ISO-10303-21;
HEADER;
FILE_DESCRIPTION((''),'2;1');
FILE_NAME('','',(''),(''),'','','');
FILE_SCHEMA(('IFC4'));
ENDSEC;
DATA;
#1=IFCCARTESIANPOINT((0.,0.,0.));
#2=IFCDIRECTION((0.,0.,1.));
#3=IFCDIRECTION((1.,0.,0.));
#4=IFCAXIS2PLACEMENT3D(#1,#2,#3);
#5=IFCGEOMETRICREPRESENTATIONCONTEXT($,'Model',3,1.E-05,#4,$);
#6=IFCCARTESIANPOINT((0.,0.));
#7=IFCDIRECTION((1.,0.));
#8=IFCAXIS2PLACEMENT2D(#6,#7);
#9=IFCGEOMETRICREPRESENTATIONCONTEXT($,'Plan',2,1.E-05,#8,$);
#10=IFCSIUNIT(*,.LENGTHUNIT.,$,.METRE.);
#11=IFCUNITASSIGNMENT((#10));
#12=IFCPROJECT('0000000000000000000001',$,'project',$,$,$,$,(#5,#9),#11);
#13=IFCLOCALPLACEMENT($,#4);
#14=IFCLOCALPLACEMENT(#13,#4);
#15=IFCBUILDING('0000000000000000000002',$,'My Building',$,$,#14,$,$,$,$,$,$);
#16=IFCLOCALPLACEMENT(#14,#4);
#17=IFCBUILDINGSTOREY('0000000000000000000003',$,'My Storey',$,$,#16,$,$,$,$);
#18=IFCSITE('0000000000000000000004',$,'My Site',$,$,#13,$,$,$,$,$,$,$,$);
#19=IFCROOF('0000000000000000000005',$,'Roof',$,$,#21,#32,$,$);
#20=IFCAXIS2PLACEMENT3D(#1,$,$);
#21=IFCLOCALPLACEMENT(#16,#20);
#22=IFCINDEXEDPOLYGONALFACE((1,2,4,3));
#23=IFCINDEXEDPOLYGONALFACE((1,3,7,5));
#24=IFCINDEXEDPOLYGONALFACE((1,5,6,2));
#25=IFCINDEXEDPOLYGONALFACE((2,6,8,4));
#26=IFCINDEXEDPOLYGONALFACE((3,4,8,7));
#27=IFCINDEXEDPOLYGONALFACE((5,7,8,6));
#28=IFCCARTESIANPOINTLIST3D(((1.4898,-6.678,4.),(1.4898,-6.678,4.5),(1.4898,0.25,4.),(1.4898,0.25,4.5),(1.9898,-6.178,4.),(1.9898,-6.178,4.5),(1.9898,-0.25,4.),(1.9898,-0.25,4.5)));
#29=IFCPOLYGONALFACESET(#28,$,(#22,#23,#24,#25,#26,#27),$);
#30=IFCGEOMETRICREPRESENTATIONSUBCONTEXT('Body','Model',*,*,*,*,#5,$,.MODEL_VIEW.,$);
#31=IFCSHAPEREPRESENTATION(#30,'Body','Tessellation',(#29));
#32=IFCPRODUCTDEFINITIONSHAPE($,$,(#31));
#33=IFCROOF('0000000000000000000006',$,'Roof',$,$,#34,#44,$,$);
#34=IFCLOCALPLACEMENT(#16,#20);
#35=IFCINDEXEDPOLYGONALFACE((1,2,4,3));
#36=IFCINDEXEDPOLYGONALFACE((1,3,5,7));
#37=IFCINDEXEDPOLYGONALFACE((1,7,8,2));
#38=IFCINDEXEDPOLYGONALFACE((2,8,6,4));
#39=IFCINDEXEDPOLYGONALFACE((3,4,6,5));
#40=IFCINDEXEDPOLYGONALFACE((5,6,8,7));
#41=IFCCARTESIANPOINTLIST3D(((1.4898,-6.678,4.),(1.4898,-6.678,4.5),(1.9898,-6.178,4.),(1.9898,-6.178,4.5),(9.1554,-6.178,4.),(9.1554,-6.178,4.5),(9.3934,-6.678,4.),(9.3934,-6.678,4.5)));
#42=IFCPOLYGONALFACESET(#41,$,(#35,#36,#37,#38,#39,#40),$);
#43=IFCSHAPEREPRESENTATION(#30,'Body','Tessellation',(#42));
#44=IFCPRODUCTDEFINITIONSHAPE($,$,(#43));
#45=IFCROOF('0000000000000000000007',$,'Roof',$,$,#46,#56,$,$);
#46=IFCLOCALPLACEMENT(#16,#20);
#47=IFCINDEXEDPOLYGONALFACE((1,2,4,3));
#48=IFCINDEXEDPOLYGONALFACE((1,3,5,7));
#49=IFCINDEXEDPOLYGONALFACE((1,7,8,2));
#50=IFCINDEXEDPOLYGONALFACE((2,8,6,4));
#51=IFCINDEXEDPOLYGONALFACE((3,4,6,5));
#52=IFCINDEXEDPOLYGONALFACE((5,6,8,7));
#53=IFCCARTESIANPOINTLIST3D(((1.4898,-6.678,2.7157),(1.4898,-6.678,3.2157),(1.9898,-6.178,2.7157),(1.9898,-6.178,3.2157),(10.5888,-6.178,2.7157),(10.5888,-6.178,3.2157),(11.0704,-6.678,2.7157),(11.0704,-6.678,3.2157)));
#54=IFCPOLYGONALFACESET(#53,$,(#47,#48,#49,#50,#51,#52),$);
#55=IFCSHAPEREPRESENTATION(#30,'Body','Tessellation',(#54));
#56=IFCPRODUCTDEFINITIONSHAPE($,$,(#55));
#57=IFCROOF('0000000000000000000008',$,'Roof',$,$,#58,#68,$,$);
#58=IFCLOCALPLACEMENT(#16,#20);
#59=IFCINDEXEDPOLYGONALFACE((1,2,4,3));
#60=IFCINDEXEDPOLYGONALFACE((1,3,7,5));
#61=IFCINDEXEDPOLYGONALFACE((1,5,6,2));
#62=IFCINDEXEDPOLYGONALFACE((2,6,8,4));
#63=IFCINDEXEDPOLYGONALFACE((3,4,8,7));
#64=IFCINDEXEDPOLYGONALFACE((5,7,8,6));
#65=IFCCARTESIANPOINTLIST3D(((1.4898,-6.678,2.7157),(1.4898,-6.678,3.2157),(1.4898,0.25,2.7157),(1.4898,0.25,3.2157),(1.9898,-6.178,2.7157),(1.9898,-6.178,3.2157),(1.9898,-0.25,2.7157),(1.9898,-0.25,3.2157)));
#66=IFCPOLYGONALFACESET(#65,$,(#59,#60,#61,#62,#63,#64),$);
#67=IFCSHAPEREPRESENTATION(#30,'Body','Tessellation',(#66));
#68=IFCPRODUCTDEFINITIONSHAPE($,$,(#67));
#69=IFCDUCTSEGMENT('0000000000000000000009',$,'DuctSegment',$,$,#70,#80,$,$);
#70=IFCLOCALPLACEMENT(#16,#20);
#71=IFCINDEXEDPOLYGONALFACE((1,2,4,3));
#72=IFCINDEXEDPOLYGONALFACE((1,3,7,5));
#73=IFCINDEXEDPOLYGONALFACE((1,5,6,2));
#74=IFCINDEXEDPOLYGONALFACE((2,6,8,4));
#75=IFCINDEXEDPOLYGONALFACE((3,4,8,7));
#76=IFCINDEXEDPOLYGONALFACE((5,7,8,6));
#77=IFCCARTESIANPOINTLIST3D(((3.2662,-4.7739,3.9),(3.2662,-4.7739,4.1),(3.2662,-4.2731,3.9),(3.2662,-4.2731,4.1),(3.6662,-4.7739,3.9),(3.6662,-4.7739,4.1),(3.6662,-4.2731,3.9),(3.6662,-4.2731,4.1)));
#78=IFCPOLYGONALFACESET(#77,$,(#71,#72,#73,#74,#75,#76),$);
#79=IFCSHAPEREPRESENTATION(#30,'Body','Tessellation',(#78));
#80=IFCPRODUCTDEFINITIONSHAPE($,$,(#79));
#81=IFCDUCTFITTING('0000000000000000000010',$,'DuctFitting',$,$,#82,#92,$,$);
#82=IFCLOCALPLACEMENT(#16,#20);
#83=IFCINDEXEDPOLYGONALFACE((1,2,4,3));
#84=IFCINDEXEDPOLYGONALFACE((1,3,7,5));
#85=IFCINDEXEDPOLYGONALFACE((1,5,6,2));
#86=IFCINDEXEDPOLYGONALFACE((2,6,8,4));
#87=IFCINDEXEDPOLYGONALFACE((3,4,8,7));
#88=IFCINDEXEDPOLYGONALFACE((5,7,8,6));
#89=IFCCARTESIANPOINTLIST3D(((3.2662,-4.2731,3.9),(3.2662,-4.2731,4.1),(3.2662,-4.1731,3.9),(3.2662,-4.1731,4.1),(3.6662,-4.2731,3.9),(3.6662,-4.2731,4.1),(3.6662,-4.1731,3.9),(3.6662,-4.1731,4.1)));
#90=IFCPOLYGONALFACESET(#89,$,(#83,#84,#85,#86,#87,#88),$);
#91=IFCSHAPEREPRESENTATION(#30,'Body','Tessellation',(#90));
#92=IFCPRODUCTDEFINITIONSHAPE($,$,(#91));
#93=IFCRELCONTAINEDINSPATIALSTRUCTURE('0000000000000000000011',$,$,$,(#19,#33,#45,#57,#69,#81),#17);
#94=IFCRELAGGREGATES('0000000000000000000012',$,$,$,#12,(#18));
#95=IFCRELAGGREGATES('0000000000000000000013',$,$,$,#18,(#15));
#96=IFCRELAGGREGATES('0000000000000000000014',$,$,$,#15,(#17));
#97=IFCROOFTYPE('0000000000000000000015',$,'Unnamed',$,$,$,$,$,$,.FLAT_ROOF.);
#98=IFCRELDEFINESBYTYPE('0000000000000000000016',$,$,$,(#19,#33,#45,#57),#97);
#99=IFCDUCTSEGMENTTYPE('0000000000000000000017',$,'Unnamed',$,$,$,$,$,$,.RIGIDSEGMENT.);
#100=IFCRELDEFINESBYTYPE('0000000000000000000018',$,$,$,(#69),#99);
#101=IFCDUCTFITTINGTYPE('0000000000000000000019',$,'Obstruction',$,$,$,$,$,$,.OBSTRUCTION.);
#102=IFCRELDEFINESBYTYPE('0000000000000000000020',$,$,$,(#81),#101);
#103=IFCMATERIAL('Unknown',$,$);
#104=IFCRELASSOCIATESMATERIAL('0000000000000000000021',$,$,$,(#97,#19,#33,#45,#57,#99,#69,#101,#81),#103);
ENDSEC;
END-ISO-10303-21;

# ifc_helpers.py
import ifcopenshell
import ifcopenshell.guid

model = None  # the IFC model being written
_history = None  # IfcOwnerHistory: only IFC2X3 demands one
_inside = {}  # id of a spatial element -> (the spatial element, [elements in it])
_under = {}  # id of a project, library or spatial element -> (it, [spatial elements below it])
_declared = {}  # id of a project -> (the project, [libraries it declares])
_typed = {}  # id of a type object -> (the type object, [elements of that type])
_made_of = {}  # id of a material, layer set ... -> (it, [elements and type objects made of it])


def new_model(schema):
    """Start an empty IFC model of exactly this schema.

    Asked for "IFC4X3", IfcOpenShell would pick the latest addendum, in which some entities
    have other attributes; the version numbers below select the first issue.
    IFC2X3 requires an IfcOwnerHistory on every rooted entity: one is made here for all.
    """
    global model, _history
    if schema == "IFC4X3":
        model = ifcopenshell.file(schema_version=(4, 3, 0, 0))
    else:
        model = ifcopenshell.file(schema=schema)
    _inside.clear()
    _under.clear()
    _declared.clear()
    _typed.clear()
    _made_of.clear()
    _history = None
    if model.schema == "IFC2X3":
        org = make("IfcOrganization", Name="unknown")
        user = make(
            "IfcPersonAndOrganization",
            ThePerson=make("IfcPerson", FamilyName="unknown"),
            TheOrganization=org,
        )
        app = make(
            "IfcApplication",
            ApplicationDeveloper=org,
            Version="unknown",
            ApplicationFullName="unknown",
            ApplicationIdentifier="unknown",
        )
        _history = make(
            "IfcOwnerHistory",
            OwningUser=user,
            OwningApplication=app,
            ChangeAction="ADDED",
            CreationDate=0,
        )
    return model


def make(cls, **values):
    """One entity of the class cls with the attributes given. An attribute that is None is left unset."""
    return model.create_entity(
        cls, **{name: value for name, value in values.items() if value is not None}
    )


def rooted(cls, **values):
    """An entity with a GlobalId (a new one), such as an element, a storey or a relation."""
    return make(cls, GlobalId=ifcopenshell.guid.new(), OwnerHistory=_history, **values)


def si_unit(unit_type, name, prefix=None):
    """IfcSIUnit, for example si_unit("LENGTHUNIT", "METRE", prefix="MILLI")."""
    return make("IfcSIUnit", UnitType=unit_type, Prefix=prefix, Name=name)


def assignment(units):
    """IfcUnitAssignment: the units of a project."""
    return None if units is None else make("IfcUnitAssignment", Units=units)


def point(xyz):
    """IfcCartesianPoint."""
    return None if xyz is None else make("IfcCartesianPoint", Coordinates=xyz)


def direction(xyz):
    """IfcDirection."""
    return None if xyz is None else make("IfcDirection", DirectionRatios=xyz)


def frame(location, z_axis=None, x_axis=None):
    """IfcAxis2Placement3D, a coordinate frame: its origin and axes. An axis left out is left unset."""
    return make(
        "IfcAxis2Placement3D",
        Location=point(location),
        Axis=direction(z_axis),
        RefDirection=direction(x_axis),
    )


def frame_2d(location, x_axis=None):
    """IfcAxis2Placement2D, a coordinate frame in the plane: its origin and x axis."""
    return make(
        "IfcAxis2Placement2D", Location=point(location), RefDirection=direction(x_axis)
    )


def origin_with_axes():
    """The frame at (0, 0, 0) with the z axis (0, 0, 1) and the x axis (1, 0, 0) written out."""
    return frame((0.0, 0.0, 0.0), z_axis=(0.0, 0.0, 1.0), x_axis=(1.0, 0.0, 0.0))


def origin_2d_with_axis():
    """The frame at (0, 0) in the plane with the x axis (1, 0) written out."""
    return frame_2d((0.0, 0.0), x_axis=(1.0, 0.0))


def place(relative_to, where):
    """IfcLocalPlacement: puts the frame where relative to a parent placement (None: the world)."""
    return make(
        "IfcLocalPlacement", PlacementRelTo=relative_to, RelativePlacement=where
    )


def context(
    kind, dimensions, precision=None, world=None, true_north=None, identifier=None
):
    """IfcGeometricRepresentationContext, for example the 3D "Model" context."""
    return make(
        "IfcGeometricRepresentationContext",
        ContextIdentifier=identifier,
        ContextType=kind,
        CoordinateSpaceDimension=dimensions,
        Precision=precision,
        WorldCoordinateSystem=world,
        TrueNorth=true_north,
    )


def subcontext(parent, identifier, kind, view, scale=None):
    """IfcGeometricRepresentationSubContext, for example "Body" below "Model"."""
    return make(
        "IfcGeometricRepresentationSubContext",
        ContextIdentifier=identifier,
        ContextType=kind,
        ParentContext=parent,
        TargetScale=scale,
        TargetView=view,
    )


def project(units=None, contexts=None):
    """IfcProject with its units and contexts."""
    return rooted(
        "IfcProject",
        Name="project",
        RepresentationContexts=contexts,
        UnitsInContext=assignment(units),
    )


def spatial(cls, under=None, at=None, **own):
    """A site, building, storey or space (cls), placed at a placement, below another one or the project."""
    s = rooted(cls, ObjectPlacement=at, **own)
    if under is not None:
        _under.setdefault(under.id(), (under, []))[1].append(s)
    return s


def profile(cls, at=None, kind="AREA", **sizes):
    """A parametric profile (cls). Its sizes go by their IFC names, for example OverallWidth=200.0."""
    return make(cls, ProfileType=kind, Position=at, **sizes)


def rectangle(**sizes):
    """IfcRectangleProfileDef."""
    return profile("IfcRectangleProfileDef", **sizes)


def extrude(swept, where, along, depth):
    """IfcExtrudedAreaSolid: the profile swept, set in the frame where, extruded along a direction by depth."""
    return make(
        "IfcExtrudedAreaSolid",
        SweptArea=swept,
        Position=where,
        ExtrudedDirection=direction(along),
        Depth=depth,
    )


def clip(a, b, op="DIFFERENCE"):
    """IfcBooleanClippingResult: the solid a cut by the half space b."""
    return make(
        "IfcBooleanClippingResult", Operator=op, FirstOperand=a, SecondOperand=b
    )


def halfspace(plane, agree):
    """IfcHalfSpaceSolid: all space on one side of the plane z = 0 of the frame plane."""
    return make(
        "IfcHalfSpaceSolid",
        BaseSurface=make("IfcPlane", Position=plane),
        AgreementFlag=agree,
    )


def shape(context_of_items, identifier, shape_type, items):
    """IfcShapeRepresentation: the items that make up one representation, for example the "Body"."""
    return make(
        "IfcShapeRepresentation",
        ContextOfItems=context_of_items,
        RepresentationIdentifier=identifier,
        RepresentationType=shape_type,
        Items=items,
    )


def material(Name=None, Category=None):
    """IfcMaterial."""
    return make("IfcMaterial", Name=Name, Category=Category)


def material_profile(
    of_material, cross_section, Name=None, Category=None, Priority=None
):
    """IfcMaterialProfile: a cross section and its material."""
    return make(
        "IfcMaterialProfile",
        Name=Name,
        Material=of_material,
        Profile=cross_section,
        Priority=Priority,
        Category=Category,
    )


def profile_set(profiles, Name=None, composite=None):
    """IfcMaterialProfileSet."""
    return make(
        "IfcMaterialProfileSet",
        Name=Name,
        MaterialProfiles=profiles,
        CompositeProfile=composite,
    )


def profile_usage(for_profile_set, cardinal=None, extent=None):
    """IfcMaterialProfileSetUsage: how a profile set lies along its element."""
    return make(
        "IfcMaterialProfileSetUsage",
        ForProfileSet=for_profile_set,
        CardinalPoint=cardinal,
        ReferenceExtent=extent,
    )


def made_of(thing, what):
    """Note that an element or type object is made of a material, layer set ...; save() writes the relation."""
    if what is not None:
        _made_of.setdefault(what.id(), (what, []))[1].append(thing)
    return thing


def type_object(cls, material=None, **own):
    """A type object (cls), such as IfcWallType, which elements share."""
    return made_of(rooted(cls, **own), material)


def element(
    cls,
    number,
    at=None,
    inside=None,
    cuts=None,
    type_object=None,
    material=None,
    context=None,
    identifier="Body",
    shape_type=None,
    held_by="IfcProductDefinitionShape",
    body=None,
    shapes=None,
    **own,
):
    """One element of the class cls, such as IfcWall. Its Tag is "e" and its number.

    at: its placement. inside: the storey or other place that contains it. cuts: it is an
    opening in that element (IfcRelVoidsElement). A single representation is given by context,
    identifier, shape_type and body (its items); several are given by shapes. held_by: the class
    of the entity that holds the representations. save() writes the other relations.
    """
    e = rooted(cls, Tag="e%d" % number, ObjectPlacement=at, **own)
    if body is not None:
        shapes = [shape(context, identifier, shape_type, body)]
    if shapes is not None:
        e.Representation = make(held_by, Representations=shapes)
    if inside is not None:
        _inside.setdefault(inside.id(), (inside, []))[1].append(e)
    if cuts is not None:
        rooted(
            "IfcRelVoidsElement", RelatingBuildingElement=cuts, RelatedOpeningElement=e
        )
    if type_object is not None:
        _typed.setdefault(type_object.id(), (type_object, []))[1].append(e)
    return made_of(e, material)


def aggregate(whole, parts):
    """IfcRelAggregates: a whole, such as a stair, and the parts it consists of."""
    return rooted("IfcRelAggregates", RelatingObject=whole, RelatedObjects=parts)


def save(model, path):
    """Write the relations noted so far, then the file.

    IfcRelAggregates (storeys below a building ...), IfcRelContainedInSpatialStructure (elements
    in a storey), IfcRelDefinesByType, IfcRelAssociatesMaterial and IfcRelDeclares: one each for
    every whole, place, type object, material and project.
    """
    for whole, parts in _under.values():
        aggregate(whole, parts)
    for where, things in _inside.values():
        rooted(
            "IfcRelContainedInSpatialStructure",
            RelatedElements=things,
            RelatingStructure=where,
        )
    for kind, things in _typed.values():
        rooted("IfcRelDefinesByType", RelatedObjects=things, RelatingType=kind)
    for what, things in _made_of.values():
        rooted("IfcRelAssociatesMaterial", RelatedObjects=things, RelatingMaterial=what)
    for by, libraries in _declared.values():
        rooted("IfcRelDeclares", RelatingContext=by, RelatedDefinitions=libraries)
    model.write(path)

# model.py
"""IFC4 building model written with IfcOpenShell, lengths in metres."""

from ifc_helpers import new_model, si_unit, frame, origin_with_axes, origin_2d_with_axis, place, context, subcontext, project, spatial, rectangle, extrude, clip, halfspace, material, material_profile, profile_set, profile_usage, type_object, element, save


model = new_model("IFC4")

# Units and contexts
model_context = context("Model", 3, precision=1e-05, world=origin_with_axes())
plan_context = context("Plan", 2, precision=1e-05, world=origin_2d_with_axis())
body_context_1 = subcontext(model_context, "Body", "Model", "MODEL_VIEW")
ifc_project = project(units=[si_unit("LENGTHUNIT", "METRE")], contexts=[model_context, plan_context])

# Site, building, storey
site_placement = place(None, origin_with_axes())
site = spatial("IfcSite", under=ifc_project, at=site_placement, Name="My Site")
building_placement = place(site_placement, origin_with_axes())
building = spatial("IfcBuilding", under=site, at=building_placement, Name="My Building")
storey_placement = place(building_placement, origin_with_axes())
storey = spatial("IfcBuildingStorey", under=building, at=storey_placement, Name="My Storey")

# Shared definitions
ifc_material = material(Name="Unknown")

# Roofs
ifc_material_profile_1 = material_profile(ifc_material, rectangle(XDim=0.5, YDim=0.5))
ifc_profile_set_1 = profile_set([ifc_material_profile_1])
ifc_profile_usage_1 = profile_usage(ifc_profile_set_1, cardinal=5)
roof_type = type_object("IfcRoofType", Name="Unnamed", PredefinedType="FLAT_ROOF", material=ifc_profile_set_1)
roof_1_placement = place(storey_placement, frame((1.7398, 0.25, 4.25), z_axis=(0.0, -1.0, 0.0), x_axis=(1.0, 0.0, 0.0)))
element("IfcRoof", 1, at=roof_1_placement, inside=storey, type_object=roof_type, material=ifc_profile_usage_1, Name="Roof", context=body_context_1, shape_type="Clipping", body=[
    clip(clip(extrude(rectangle(XDim=0.5, YDim=0.5), origin_with_axes(), (0.0, 0.0, 1.0), 6.928), halfspace(frame((-0.25, -4.0, 6.928), z_axis=(0.707107, 0.0, 0.707107), x_axis=(0.0, -1.0, 0.0)), False)), halfspace(frame((-0.25, -4.0, 0.0), z_axis=(0.707107, 0.0, -0.707107), x_axis=(0.0, -1.0, 0.0)), False)),
])
ifc_profile_usage_2 = profile_usage(ifc_profile_set_1, cardinal=5)
roof_2_placement = place(storey_placement, frame((1.4898, -6.428, 4.25), z_axis=(1.0, 0.0, 0.0), x_axis=(0.0, 1.0, 0.0)))
element("IfcRoof", 2, at=roof_2_placement, inside=storey, type_object=roof_type, material=ifc_profile_usage_2, Name="Roof", context=body_context_1, shape_type="Clipping", body=[
    clip(clip(extrude(rectangle(XDim=0.5, YDim=0.5), origin_with_axes(), (0.0, 0.0, 1.0), 8.6067), halfspace(frame((-0.25, -4.0, 7.9037), z_axis=(0.429837, 0.0, 0.902907), x_axis=(0.000001, -1.0, 0.0)), False)), halfspace(frame((-0.25, -4.0, 0.0), z_axis=(0.707107, 0.0, -0.707107), x_axis=(0.0, -1.0, 0.0)), False)),
])
ifc_profile_usage_3 = profile_usage(ifc_profile_set_1, cardinal=5)
roof_3_placement = place(storey_placement, frame((1.4898, -6.428, 2.9657), z_axis=(1.0, 0.0, 0.0), x_axis=(0.0, 1.0, 0.0)))
element("IfcRoof", 3, at=roof_3_placement, inside=storey, type_object=roof_type, material=ifc_profile_usage_3, Name="Roof", context=body_context_1, shape_type="Clipping", body=[
    clip(clip(extrude(rectangle(XDim=0.5, YDim=0.5), origin_with_axes(), (0.0, 0.0, 1.0), 10.09), halfspace(frame((-0.25, -2.9657, 0.0), z_axis=(0.707107, 0.0, -0.707107), x_axis=(0.0, -1.0, 0.0)), False)), halfspace(frame((-0.25, -2.9657, 9.5806), z_axis=(0.693755, 0.0, 0.720211), x_axis=(0.0, -1.0, 0.0)), False)),
])
ifc_profile_usage_4 = profile_usage(ifc_profile_set_1, cardinal=5)
roof_4_placement = place(storey_placement, frame((1.7398, 0.25, 2.9657), z_axis=(0.0, -1.0, 0.0), x_axis=(1.0, 0.0, 0.0)))
element("IfcRoof", 4, at=roof_4_placement, inside=storey, type_object=roof_type, material=ifc_profile_usage_4, Name="Roof", context=body_context_1, shape_type="Clipping", body=[
    clip(clip(extrude(rectangle(XDim=0.5, YDim=0.5), origin_with_axes(), (0.0, 0.0, 1.0), 6.928), halfspace(frame((-0.25, -2.9657, 0.0), z_axis=(0.707107, 0.0, -0.707107), x_axis=(0.0, -1.0, 0.0)), False)), halfspace(frame((-0.25, -2.9657, 6.928), z_axis=(0.707107, 0.0, 0.707107), x_axis=(0.0, -1.0, 0.0)), False)),
])

# Duct segment
ifc_material_profile_2 = material_profile(ifc_material, rectangle(XDim=0.4, YDim=0.2))
ifc_profile_set_2 = profile_set([ifc_material_profile_2])
ifc_profile_usage_5 = profile_usage(ifc_profile_set_2, cardinal=5)
duct_segment_type = type_object("IfcDuctSegmentType", Name="Unnamed", PredefinedType="RIGIDSEGMENT", material=ifc_profile_set_2)
duct_segment_placement = place(storey_placement, frame((3.4662, -4.2731, 4.0), z_axis=(0.0, -1.0, 0.0), x_axis=(1.0, 0.0, 0.0)))
element("IfcDuctSegment", 5, at=duct_segment_placement, inside=storey, type_object=duct_segment_type, material=ifc_profile_usage_5, Name="DuctSegment", context=body_context_1, shape_type="SweptSolid", body=[
    extrude(rectangle(XDim=0.4, YDim=0.2), origin_with_axes(), (0.0, 0.0, 1.0), 0.5008),
])

# Duct fitting
ifc_material_profile_3 = material_profile(ifc_material, rectangle(XDim=0.4, YDim=0.2))
ifc_profile_set_3 = profile_set([ifc_material_profile_3])
ifc_profile_usage_6 = profile_usage(ifc_profile_set_3, cardinal=5)
duct_fitting_type = type_object("IfcDuctFittingType", Name="Obstruction", PredefinedType="OBSTRUCTION", material=ifc_profile_set_3)
duct_fitting_placement = place(storey_placement, frame((3.4662, -4.1731, 4.0), z_axis=(0.0, -1.0, 0.0), x_axis=(1.0, 0.0, 0.0)))
element("IfcDuctFitting", 6, at=duct_fitting_placement, inside=storey, type_object=duct_fitting_type, material=ifc_profile_usage_6, Name="DuctFitting", context=body_context_1, shape_type="SweptSolid", body=[
    extrude(rectangle(XDim=0.4, YDim=0.2), origin_with_axes(), (0.0, 0.0, 1.0), 0.1),
])

save(model, "model.ifc")
